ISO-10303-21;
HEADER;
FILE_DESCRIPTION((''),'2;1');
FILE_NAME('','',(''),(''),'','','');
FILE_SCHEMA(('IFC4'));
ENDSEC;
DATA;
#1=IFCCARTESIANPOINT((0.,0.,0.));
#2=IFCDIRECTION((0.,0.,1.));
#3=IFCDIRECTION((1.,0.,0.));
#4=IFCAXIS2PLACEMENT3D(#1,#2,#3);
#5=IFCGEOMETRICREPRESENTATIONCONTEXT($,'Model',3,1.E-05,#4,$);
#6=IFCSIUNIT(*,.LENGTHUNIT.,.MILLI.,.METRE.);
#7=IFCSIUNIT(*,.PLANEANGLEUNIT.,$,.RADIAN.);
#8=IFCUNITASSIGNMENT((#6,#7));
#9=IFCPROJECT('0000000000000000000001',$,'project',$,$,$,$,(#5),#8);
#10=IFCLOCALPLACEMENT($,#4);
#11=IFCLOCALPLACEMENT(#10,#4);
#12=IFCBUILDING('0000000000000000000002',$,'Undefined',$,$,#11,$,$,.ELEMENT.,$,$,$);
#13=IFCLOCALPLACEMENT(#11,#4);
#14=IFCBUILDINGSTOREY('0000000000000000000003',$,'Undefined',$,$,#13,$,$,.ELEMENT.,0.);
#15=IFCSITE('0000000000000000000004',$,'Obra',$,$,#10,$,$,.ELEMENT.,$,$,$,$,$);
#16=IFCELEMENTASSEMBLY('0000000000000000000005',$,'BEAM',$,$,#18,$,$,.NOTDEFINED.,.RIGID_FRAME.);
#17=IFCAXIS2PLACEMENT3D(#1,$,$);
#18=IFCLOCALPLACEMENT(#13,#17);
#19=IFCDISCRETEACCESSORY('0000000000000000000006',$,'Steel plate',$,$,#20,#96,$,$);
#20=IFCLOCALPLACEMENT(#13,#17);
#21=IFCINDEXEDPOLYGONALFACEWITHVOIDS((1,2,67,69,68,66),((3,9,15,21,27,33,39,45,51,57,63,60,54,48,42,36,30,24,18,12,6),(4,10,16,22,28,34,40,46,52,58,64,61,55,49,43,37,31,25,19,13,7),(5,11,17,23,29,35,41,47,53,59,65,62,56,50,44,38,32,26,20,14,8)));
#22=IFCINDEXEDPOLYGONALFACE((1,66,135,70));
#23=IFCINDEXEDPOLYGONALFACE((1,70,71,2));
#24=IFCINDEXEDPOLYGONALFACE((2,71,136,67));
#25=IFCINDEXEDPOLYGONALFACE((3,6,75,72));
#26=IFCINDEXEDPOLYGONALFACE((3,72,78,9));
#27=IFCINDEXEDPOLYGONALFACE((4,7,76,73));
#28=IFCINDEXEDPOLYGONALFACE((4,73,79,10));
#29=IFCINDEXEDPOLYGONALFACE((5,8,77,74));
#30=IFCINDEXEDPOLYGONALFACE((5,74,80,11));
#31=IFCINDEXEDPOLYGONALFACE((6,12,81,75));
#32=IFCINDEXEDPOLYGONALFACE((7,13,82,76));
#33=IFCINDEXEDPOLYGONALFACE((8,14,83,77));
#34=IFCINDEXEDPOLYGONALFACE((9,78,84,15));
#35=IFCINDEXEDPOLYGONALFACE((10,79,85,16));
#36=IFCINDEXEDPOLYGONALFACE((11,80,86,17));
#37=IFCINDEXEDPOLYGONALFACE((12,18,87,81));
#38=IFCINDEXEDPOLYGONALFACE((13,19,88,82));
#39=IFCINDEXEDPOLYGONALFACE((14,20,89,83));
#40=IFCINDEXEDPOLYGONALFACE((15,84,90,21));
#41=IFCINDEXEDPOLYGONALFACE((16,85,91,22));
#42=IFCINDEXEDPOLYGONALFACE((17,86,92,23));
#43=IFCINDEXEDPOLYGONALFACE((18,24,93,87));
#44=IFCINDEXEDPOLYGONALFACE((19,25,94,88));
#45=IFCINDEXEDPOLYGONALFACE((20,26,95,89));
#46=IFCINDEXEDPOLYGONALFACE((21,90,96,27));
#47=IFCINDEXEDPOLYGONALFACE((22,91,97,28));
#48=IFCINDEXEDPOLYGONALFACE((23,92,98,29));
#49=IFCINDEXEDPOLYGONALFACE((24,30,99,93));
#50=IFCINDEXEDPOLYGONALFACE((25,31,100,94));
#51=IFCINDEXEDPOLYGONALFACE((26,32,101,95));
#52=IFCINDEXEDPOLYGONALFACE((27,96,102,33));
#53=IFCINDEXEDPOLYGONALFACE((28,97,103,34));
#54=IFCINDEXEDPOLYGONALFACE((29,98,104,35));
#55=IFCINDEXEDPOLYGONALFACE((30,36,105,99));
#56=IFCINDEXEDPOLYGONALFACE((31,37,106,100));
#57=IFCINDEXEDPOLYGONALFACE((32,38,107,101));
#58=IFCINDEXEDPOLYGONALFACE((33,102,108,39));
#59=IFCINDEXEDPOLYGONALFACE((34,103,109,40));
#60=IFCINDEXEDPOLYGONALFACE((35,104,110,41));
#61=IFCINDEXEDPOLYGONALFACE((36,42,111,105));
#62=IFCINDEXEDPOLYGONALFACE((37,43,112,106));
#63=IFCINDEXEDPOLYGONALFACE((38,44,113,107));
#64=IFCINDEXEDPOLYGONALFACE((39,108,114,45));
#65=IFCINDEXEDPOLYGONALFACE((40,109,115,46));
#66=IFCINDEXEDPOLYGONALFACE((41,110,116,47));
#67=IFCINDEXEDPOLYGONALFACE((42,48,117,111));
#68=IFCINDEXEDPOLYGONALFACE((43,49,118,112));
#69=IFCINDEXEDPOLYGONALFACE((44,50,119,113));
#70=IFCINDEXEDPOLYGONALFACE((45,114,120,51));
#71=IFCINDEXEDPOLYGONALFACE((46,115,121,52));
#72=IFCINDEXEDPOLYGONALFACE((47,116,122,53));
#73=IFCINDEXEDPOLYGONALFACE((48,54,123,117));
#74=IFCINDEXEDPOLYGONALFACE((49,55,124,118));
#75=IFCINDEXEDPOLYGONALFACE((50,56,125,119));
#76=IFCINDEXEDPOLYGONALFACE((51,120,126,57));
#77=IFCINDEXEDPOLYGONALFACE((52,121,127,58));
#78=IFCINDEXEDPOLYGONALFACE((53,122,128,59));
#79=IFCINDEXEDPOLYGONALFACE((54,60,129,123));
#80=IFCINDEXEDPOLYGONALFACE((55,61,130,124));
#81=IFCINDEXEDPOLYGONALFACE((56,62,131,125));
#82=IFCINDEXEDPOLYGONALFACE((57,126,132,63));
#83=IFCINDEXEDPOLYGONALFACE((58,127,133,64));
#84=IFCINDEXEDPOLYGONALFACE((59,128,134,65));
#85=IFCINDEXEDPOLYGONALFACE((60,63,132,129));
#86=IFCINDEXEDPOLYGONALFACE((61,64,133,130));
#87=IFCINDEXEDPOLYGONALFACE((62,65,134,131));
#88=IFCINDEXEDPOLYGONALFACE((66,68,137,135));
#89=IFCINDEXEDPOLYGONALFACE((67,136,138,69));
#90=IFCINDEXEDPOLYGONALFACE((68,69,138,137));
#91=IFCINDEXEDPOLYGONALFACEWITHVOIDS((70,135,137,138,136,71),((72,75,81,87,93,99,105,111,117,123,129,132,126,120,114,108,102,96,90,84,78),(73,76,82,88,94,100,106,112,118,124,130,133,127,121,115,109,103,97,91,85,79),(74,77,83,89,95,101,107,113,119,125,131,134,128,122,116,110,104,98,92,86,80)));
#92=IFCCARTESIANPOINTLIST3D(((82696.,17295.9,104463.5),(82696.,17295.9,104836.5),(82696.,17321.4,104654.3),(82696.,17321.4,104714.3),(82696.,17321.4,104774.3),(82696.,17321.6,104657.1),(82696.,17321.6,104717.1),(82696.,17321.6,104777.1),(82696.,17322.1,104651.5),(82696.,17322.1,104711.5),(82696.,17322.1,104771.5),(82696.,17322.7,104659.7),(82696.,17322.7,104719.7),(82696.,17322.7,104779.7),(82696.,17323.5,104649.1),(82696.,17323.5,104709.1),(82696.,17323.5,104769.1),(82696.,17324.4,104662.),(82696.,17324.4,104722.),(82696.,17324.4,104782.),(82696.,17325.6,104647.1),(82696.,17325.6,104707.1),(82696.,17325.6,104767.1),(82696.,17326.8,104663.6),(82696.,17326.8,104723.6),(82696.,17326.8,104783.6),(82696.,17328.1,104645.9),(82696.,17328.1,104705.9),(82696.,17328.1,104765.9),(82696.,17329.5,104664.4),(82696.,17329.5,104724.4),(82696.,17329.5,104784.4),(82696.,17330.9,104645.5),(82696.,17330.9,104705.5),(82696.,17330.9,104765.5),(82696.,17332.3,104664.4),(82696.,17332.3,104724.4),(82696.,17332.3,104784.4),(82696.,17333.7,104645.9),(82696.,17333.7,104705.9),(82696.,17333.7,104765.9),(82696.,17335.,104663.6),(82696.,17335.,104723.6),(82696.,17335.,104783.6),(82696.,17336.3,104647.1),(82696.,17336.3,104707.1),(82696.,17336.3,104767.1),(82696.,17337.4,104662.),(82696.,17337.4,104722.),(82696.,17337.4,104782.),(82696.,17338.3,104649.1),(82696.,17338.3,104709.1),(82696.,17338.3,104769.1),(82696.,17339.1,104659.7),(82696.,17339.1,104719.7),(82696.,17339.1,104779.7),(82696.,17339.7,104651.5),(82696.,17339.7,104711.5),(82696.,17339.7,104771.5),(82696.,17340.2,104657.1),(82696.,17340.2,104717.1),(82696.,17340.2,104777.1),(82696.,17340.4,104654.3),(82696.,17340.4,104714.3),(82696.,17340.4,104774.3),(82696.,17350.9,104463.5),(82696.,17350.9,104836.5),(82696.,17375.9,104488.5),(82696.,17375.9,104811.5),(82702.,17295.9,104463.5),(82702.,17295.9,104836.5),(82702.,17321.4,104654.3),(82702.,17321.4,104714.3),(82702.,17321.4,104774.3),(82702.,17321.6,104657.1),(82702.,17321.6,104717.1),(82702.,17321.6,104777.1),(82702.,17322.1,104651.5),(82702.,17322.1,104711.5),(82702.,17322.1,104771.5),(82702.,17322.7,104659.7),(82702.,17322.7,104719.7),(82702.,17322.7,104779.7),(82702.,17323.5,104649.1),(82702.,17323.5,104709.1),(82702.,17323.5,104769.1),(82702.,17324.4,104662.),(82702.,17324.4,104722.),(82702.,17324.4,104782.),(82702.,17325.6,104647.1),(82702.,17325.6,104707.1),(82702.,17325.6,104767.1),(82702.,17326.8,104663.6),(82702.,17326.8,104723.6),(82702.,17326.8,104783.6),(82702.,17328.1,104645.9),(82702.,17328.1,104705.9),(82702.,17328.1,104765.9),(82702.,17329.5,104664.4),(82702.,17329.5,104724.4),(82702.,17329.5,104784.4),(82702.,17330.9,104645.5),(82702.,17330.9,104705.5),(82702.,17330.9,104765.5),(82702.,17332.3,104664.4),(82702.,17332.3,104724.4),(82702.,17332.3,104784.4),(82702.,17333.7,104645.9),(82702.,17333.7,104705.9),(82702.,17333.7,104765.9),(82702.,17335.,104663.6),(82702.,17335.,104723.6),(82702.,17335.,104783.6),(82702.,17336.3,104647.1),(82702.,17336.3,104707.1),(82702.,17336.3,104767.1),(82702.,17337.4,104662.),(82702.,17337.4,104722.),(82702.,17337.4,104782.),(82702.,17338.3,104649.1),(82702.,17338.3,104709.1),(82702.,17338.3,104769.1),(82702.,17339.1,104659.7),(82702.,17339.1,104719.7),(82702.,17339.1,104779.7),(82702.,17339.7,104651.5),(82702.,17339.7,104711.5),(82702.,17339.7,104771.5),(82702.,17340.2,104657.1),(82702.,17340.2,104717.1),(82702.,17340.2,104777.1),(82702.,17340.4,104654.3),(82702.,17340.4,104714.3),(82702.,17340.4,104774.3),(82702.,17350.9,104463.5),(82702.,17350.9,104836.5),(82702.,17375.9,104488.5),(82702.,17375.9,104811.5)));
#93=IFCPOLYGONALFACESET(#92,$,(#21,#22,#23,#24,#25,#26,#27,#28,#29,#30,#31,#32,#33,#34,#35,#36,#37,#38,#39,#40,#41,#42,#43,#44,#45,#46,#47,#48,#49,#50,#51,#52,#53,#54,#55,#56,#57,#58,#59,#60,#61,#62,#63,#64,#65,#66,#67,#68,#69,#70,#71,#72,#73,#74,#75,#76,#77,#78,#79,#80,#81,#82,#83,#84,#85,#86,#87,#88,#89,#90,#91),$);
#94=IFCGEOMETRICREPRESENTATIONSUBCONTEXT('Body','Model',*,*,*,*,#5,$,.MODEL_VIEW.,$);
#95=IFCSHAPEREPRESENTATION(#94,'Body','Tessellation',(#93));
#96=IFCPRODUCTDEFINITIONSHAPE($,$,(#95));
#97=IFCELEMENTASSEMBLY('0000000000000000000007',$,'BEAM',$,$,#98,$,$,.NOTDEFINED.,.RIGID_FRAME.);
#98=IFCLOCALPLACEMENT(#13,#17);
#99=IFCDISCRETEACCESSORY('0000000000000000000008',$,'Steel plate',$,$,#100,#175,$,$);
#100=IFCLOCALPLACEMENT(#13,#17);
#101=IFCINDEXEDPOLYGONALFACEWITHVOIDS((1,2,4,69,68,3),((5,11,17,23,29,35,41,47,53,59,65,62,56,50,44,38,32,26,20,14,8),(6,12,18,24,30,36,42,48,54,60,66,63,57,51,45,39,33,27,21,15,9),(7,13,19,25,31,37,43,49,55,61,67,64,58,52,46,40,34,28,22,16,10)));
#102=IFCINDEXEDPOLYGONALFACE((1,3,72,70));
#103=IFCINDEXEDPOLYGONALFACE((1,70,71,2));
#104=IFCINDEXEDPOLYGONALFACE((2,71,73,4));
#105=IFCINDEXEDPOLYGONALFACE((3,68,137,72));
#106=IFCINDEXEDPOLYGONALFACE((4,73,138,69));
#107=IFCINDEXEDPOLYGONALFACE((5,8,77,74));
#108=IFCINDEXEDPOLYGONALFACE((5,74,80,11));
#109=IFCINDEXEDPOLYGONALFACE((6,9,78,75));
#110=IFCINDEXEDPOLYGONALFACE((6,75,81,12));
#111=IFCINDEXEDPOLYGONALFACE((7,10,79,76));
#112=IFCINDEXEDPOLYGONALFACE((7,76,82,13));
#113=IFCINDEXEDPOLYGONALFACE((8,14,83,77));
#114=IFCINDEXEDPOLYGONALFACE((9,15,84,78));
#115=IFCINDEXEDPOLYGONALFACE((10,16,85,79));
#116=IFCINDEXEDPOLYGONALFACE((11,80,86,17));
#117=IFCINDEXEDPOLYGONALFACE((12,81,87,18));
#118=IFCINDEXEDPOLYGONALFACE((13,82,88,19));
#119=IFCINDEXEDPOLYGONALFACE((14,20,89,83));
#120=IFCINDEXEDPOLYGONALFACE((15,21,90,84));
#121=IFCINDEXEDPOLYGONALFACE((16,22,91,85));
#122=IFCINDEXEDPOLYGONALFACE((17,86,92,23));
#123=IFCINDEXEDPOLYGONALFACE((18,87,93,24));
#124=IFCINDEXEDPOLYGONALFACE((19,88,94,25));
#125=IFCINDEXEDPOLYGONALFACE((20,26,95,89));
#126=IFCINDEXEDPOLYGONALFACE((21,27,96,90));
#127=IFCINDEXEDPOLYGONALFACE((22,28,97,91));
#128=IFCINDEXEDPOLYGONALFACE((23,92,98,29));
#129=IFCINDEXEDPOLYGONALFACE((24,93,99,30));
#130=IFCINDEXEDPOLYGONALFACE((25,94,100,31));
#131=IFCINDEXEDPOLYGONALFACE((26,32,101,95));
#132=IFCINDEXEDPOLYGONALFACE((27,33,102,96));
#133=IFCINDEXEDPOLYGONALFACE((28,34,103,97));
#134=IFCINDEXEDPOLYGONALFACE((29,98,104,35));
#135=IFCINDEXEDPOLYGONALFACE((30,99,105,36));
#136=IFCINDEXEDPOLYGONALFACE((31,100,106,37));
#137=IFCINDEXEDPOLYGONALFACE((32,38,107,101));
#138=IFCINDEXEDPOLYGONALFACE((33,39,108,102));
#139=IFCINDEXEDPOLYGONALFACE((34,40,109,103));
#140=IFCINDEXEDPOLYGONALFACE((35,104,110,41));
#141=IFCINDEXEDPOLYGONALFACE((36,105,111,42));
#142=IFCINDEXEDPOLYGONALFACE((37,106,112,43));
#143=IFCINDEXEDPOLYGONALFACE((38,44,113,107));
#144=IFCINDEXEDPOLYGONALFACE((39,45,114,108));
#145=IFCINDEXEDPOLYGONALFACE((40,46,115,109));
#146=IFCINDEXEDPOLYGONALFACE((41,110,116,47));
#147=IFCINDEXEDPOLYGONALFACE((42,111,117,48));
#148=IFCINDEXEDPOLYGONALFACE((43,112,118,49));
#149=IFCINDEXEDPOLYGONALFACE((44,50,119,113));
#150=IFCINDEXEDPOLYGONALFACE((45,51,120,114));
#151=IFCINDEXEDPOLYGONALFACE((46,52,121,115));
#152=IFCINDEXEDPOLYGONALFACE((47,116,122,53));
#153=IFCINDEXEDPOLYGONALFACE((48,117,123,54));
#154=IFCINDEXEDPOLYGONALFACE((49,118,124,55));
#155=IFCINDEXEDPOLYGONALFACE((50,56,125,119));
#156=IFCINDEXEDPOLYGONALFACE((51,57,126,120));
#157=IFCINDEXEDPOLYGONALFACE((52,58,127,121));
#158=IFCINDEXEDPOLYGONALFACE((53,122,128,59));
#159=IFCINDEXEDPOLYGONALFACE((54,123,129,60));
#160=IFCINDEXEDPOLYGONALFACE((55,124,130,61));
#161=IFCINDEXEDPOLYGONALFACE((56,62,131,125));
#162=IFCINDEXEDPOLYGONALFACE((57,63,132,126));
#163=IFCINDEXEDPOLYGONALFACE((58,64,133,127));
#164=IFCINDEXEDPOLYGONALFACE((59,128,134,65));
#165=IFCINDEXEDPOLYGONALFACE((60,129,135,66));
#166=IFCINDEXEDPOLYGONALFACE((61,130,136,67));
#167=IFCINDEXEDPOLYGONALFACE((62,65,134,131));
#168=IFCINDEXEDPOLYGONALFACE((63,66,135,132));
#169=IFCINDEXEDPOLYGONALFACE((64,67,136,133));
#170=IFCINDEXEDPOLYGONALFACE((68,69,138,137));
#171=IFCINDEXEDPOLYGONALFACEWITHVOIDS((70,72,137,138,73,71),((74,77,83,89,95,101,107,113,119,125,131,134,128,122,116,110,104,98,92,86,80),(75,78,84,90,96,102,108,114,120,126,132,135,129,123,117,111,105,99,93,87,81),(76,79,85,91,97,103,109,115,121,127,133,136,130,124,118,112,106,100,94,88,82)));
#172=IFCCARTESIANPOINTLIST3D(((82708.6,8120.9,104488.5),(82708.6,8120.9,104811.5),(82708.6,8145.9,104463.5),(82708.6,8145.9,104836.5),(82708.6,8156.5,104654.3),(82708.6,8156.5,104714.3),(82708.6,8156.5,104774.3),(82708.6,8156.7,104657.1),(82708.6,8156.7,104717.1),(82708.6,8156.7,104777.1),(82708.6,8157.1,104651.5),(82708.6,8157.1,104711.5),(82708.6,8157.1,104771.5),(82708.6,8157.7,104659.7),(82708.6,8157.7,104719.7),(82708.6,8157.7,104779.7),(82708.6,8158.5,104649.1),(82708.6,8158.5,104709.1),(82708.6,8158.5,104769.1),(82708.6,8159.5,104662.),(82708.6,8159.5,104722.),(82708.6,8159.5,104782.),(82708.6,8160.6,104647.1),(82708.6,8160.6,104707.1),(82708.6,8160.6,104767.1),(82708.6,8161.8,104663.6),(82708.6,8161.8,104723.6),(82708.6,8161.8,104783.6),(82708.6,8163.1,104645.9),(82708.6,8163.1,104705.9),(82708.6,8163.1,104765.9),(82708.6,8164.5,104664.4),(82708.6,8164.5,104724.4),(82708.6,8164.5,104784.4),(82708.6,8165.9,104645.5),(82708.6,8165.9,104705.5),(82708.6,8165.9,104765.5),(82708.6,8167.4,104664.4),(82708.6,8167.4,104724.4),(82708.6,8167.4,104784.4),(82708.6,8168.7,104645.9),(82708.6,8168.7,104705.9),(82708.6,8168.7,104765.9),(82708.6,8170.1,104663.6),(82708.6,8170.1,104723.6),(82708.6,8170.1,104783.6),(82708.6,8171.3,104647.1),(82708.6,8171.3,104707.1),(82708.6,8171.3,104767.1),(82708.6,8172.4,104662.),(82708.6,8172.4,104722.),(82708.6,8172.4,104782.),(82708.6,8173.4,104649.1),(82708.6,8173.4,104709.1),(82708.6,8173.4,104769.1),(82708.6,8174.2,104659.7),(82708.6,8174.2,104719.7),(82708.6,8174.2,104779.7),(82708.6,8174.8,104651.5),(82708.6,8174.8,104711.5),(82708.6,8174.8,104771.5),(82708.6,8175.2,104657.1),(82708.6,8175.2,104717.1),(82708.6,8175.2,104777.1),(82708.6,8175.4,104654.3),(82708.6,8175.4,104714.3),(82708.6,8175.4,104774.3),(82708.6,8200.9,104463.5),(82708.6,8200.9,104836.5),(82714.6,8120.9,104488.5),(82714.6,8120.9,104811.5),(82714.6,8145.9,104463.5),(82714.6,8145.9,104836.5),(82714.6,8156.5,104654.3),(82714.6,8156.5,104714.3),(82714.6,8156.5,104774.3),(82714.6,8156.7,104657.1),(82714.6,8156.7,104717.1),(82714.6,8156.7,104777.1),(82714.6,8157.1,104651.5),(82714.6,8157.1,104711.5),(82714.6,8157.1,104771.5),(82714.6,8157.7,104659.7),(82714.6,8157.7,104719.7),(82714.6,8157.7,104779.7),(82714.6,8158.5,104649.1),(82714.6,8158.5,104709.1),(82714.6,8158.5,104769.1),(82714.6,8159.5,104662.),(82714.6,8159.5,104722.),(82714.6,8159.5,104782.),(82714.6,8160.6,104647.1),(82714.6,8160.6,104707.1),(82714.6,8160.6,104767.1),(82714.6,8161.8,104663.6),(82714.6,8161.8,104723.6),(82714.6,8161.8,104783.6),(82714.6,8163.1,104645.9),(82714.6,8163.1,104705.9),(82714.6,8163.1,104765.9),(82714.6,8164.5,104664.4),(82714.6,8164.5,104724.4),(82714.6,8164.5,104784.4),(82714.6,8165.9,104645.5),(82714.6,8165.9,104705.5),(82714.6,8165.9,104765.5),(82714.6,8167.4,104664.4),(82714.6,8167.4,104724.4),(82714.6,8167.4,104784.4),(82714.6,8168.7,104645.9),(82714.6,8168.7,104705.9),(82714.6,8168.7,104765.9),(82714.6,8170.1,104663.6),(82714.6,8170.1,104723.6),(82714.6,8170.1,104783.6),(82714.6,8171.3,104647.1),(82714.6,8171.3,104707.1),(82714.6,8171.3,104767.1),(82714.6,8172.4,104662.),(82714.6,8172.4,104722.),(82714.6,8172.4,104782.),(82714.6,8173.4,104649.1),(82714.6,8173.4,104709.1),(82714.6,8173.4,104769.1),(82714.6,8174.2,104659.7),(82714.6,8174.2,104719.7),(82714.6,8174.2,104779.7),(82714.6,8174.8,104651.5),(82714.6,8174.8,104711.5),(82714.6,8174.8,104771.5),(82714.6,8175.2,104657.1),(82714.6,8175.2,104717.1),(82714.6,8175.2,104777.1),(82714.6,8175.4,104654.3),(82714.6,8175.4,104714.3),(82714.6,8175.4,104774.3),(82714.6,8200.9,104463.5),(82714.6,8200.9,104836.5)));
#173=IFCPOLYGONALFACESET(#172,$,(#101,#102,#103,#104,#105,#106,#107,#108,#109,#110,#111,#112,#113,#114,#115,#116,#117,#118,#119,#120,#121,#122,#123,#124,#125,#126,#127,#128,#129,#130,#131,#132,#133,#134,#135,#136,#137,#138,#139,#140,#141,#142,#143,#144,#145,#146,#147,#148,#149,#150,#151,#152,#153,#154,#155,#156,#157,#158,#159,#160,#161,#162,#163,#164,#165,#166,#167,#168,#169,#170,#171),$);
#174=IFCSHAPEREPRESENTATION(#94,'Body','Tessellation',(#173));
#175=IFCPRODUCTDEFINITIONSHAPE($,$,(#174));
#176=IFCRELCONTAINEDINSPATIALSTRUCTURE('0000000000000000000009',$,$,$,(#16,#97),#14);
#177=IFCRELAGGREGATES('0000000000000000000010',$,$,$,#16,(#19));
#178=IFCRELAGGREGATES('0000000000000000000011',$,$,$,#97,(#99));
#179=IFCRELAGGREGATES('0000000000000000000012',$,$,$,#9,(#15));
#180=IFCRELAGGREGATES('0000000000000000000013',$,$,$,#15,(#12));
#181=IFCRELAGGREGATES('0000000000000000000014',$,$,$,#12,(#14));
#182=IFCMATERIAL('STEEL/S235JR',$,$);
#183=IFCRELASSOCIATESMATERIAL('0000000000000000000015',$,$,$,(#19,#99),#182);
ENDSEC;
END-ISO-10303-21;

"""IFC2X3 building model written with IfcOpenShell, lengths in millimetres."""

from ifc_helpers import new_model, si_unit, frame, origin_with_axes, origin_2d_with_axis, place, context, subcontext, project, spatial, polyline, circle, outline, extrude, source, transform, mapped, material, element, aggregate, save


model = new_model("IFC2X3")

# Units and contexts
model_context = context("Model", 3, precision=1e-05, world=origin_with_axes())
body_context = subcontext(model_context, "Body", "Model", "MODEL_VIEW")
ifc_project = project(units=[si_unit("LENGTHUNIT", "METRE", prefix="MILLI"), si_unit("PLANEANGLEUNIT", "RADIAN")], contexts=[model_context])

# Site, building, storey
site_placement = place(None, origin_with_axes())
site = spatial("IfcSite", under=ifc_project, at=site_placement, Name="Obra", CompositionType="ELEMENT")
building_placement = place(site_placement, origin_with_axes())
building = spatial("IfcBuilding", under=site, at=building_placement, Name="Undefined", CompositionType="ELEMENT")
storey_placement = place(building_placement, origin_with_axes())
storey = spatial("IfcBuildingStorey", under=building, at=storey_placement, Name="Undefined", CompositionType="ELEMENT", Elevation=0.0)

# Shared definitions
ifc_material = material(Name="STEEL/S235JR")

# Element assembly, discrete accessory, opening
assembly_1_placement = place(storey_placement, origin_with_axes())
assembly_1 = element("IfcElementAssembly", 1, at=assembly_1_placement, inside=storey, Name="BEAM", AssemblyPlace="NOTDEFINED", PredefinedType="RIGID_FRAME")
discrete_accessory_1_placement = place(assembly_1_placement, frame((82699.0, 17295.9, 104463.5), z_axis=(1.0, 0.0, 0.0), x_axis=(0.0, 1.0, 0.0)))
discrete_accessory_1 = element("IfcDiscreteAccessory", 2, at=discrete_accessory_1_placement, material=ifc_material, Name="Steel plate", context=body_context, shape_type="SweptSolid", body=[
    extrude(outline(polyline([(0.0, 0.0), (55.0, 0.0), (80.0, 25.0), (80.0, 348.0), (55.0, 373.0), (0.0, 373.0), (0.0, 0.0)])), frame((0.0, 0.0, -3.0), z_axis=(0.0, 0.0, 1.0), x_axis=(1.0, 0.0, 0.0)), (0.0, 0.0, 1.0), 6.0),
])
shared_shape_1 = source(origin_with_axes(), body_context, "Body", "SweptSolid", [
    extrude(circle(Radius=9.5, at=origin_2d_with_axis()), frame((0.0, -9.4, 0.0), z_axis=(0.0, 1.0, 0.0), x_axis=(1.0, 0.0, 0.0)), (0.0, 0.0, 1.0), 6.2),
])
opening_1_placement = place(assembly_1_placement, frame((82705.3, 17365.9, 104850.0), z_axis=(0.0, -1.0, 0.0), x_axis=(0.0, 0.0, -1.0)))
element("IfcOpeningElement", 3, at=opening_1_placement, cuts=discrete_accessory_1, ObjectType="Opening", context=body_context, shape_type="MappedRepresentation", body=[
    mapped(shared_shape_1, transform((75.0, 0.0, 35.0))),
    mapped(shared_shape_1, transform((135.0, 0.0, 35.0))),
    mapped(shared_shape_1, transform((195.0, 0.0, 35.0))),
])

# Element assembly, discrete accessory, opening
assembly_2_placement = place(storey_placement, origin_with_axes())
assembly_2 = element("IfcElementAssembly", 4, at=assembly_2_placement, inside=storey, Name="BEAM", AssemblyPlace="NOTDEFINED", PredefinedType="RIGID_FRAME")
discrete_accessory_2_placement = place(assembly_2_placement, frame((82711.6, 8200.9, 104463.5), z_axis=(-1.0, 0.0, 0.0), x_axis=(0.0, -1.0, 0.0)))
discrete_accessory_2 = element("IfcDiscreteAccessory", 5, at=discrete_accessory_2_placement, material=ifc_material, Name="Steel plate", context=body_context, shape_type="SweptSolid", body=[
    extrude(outline(polyline([(0.0, 0.0), (55.0, 0.0), (80.0, 25.0), (80.0, 348.0), (55.0, 373.0), (0.0, 373.0), (0.0, 0.0)])), frame((0.0, 0.0, -3.0), z_axis=(0.0, 0.0, 1.0), x_axis=(1.0, 0.0, 0.0)), (0.0, 0.0, 1.0), 6.0),
])
opening_2_placement = place(assembly_2_placement, frame((82705.3, 8130.9, 104850.0), z_axis=(0.0, 1.0, 0.0), x_axis=(0.0, 0.0, -1.0)))
element("IfcOpeningElement", 6, at=opening_2_placement, cuts=discrete_accessory_2, ObjectType="Opening", context=body_context, shape_type="MappedRepresentation", body=[
    mapped(shared_shape_1, transform((75.0, 0.0, 35.0))),
    mapped(shared_shape_1, transform((135.0, 0.0, 35.0))),
    mapped(shared_shape_1, transform((195.0, 0.0, 35.0))),
])

aggregate(assembly_1, [discrete_accessory_1])
aggregate(assembly_2, [discrete_accessory_2])

save(model, "model.ifc")
